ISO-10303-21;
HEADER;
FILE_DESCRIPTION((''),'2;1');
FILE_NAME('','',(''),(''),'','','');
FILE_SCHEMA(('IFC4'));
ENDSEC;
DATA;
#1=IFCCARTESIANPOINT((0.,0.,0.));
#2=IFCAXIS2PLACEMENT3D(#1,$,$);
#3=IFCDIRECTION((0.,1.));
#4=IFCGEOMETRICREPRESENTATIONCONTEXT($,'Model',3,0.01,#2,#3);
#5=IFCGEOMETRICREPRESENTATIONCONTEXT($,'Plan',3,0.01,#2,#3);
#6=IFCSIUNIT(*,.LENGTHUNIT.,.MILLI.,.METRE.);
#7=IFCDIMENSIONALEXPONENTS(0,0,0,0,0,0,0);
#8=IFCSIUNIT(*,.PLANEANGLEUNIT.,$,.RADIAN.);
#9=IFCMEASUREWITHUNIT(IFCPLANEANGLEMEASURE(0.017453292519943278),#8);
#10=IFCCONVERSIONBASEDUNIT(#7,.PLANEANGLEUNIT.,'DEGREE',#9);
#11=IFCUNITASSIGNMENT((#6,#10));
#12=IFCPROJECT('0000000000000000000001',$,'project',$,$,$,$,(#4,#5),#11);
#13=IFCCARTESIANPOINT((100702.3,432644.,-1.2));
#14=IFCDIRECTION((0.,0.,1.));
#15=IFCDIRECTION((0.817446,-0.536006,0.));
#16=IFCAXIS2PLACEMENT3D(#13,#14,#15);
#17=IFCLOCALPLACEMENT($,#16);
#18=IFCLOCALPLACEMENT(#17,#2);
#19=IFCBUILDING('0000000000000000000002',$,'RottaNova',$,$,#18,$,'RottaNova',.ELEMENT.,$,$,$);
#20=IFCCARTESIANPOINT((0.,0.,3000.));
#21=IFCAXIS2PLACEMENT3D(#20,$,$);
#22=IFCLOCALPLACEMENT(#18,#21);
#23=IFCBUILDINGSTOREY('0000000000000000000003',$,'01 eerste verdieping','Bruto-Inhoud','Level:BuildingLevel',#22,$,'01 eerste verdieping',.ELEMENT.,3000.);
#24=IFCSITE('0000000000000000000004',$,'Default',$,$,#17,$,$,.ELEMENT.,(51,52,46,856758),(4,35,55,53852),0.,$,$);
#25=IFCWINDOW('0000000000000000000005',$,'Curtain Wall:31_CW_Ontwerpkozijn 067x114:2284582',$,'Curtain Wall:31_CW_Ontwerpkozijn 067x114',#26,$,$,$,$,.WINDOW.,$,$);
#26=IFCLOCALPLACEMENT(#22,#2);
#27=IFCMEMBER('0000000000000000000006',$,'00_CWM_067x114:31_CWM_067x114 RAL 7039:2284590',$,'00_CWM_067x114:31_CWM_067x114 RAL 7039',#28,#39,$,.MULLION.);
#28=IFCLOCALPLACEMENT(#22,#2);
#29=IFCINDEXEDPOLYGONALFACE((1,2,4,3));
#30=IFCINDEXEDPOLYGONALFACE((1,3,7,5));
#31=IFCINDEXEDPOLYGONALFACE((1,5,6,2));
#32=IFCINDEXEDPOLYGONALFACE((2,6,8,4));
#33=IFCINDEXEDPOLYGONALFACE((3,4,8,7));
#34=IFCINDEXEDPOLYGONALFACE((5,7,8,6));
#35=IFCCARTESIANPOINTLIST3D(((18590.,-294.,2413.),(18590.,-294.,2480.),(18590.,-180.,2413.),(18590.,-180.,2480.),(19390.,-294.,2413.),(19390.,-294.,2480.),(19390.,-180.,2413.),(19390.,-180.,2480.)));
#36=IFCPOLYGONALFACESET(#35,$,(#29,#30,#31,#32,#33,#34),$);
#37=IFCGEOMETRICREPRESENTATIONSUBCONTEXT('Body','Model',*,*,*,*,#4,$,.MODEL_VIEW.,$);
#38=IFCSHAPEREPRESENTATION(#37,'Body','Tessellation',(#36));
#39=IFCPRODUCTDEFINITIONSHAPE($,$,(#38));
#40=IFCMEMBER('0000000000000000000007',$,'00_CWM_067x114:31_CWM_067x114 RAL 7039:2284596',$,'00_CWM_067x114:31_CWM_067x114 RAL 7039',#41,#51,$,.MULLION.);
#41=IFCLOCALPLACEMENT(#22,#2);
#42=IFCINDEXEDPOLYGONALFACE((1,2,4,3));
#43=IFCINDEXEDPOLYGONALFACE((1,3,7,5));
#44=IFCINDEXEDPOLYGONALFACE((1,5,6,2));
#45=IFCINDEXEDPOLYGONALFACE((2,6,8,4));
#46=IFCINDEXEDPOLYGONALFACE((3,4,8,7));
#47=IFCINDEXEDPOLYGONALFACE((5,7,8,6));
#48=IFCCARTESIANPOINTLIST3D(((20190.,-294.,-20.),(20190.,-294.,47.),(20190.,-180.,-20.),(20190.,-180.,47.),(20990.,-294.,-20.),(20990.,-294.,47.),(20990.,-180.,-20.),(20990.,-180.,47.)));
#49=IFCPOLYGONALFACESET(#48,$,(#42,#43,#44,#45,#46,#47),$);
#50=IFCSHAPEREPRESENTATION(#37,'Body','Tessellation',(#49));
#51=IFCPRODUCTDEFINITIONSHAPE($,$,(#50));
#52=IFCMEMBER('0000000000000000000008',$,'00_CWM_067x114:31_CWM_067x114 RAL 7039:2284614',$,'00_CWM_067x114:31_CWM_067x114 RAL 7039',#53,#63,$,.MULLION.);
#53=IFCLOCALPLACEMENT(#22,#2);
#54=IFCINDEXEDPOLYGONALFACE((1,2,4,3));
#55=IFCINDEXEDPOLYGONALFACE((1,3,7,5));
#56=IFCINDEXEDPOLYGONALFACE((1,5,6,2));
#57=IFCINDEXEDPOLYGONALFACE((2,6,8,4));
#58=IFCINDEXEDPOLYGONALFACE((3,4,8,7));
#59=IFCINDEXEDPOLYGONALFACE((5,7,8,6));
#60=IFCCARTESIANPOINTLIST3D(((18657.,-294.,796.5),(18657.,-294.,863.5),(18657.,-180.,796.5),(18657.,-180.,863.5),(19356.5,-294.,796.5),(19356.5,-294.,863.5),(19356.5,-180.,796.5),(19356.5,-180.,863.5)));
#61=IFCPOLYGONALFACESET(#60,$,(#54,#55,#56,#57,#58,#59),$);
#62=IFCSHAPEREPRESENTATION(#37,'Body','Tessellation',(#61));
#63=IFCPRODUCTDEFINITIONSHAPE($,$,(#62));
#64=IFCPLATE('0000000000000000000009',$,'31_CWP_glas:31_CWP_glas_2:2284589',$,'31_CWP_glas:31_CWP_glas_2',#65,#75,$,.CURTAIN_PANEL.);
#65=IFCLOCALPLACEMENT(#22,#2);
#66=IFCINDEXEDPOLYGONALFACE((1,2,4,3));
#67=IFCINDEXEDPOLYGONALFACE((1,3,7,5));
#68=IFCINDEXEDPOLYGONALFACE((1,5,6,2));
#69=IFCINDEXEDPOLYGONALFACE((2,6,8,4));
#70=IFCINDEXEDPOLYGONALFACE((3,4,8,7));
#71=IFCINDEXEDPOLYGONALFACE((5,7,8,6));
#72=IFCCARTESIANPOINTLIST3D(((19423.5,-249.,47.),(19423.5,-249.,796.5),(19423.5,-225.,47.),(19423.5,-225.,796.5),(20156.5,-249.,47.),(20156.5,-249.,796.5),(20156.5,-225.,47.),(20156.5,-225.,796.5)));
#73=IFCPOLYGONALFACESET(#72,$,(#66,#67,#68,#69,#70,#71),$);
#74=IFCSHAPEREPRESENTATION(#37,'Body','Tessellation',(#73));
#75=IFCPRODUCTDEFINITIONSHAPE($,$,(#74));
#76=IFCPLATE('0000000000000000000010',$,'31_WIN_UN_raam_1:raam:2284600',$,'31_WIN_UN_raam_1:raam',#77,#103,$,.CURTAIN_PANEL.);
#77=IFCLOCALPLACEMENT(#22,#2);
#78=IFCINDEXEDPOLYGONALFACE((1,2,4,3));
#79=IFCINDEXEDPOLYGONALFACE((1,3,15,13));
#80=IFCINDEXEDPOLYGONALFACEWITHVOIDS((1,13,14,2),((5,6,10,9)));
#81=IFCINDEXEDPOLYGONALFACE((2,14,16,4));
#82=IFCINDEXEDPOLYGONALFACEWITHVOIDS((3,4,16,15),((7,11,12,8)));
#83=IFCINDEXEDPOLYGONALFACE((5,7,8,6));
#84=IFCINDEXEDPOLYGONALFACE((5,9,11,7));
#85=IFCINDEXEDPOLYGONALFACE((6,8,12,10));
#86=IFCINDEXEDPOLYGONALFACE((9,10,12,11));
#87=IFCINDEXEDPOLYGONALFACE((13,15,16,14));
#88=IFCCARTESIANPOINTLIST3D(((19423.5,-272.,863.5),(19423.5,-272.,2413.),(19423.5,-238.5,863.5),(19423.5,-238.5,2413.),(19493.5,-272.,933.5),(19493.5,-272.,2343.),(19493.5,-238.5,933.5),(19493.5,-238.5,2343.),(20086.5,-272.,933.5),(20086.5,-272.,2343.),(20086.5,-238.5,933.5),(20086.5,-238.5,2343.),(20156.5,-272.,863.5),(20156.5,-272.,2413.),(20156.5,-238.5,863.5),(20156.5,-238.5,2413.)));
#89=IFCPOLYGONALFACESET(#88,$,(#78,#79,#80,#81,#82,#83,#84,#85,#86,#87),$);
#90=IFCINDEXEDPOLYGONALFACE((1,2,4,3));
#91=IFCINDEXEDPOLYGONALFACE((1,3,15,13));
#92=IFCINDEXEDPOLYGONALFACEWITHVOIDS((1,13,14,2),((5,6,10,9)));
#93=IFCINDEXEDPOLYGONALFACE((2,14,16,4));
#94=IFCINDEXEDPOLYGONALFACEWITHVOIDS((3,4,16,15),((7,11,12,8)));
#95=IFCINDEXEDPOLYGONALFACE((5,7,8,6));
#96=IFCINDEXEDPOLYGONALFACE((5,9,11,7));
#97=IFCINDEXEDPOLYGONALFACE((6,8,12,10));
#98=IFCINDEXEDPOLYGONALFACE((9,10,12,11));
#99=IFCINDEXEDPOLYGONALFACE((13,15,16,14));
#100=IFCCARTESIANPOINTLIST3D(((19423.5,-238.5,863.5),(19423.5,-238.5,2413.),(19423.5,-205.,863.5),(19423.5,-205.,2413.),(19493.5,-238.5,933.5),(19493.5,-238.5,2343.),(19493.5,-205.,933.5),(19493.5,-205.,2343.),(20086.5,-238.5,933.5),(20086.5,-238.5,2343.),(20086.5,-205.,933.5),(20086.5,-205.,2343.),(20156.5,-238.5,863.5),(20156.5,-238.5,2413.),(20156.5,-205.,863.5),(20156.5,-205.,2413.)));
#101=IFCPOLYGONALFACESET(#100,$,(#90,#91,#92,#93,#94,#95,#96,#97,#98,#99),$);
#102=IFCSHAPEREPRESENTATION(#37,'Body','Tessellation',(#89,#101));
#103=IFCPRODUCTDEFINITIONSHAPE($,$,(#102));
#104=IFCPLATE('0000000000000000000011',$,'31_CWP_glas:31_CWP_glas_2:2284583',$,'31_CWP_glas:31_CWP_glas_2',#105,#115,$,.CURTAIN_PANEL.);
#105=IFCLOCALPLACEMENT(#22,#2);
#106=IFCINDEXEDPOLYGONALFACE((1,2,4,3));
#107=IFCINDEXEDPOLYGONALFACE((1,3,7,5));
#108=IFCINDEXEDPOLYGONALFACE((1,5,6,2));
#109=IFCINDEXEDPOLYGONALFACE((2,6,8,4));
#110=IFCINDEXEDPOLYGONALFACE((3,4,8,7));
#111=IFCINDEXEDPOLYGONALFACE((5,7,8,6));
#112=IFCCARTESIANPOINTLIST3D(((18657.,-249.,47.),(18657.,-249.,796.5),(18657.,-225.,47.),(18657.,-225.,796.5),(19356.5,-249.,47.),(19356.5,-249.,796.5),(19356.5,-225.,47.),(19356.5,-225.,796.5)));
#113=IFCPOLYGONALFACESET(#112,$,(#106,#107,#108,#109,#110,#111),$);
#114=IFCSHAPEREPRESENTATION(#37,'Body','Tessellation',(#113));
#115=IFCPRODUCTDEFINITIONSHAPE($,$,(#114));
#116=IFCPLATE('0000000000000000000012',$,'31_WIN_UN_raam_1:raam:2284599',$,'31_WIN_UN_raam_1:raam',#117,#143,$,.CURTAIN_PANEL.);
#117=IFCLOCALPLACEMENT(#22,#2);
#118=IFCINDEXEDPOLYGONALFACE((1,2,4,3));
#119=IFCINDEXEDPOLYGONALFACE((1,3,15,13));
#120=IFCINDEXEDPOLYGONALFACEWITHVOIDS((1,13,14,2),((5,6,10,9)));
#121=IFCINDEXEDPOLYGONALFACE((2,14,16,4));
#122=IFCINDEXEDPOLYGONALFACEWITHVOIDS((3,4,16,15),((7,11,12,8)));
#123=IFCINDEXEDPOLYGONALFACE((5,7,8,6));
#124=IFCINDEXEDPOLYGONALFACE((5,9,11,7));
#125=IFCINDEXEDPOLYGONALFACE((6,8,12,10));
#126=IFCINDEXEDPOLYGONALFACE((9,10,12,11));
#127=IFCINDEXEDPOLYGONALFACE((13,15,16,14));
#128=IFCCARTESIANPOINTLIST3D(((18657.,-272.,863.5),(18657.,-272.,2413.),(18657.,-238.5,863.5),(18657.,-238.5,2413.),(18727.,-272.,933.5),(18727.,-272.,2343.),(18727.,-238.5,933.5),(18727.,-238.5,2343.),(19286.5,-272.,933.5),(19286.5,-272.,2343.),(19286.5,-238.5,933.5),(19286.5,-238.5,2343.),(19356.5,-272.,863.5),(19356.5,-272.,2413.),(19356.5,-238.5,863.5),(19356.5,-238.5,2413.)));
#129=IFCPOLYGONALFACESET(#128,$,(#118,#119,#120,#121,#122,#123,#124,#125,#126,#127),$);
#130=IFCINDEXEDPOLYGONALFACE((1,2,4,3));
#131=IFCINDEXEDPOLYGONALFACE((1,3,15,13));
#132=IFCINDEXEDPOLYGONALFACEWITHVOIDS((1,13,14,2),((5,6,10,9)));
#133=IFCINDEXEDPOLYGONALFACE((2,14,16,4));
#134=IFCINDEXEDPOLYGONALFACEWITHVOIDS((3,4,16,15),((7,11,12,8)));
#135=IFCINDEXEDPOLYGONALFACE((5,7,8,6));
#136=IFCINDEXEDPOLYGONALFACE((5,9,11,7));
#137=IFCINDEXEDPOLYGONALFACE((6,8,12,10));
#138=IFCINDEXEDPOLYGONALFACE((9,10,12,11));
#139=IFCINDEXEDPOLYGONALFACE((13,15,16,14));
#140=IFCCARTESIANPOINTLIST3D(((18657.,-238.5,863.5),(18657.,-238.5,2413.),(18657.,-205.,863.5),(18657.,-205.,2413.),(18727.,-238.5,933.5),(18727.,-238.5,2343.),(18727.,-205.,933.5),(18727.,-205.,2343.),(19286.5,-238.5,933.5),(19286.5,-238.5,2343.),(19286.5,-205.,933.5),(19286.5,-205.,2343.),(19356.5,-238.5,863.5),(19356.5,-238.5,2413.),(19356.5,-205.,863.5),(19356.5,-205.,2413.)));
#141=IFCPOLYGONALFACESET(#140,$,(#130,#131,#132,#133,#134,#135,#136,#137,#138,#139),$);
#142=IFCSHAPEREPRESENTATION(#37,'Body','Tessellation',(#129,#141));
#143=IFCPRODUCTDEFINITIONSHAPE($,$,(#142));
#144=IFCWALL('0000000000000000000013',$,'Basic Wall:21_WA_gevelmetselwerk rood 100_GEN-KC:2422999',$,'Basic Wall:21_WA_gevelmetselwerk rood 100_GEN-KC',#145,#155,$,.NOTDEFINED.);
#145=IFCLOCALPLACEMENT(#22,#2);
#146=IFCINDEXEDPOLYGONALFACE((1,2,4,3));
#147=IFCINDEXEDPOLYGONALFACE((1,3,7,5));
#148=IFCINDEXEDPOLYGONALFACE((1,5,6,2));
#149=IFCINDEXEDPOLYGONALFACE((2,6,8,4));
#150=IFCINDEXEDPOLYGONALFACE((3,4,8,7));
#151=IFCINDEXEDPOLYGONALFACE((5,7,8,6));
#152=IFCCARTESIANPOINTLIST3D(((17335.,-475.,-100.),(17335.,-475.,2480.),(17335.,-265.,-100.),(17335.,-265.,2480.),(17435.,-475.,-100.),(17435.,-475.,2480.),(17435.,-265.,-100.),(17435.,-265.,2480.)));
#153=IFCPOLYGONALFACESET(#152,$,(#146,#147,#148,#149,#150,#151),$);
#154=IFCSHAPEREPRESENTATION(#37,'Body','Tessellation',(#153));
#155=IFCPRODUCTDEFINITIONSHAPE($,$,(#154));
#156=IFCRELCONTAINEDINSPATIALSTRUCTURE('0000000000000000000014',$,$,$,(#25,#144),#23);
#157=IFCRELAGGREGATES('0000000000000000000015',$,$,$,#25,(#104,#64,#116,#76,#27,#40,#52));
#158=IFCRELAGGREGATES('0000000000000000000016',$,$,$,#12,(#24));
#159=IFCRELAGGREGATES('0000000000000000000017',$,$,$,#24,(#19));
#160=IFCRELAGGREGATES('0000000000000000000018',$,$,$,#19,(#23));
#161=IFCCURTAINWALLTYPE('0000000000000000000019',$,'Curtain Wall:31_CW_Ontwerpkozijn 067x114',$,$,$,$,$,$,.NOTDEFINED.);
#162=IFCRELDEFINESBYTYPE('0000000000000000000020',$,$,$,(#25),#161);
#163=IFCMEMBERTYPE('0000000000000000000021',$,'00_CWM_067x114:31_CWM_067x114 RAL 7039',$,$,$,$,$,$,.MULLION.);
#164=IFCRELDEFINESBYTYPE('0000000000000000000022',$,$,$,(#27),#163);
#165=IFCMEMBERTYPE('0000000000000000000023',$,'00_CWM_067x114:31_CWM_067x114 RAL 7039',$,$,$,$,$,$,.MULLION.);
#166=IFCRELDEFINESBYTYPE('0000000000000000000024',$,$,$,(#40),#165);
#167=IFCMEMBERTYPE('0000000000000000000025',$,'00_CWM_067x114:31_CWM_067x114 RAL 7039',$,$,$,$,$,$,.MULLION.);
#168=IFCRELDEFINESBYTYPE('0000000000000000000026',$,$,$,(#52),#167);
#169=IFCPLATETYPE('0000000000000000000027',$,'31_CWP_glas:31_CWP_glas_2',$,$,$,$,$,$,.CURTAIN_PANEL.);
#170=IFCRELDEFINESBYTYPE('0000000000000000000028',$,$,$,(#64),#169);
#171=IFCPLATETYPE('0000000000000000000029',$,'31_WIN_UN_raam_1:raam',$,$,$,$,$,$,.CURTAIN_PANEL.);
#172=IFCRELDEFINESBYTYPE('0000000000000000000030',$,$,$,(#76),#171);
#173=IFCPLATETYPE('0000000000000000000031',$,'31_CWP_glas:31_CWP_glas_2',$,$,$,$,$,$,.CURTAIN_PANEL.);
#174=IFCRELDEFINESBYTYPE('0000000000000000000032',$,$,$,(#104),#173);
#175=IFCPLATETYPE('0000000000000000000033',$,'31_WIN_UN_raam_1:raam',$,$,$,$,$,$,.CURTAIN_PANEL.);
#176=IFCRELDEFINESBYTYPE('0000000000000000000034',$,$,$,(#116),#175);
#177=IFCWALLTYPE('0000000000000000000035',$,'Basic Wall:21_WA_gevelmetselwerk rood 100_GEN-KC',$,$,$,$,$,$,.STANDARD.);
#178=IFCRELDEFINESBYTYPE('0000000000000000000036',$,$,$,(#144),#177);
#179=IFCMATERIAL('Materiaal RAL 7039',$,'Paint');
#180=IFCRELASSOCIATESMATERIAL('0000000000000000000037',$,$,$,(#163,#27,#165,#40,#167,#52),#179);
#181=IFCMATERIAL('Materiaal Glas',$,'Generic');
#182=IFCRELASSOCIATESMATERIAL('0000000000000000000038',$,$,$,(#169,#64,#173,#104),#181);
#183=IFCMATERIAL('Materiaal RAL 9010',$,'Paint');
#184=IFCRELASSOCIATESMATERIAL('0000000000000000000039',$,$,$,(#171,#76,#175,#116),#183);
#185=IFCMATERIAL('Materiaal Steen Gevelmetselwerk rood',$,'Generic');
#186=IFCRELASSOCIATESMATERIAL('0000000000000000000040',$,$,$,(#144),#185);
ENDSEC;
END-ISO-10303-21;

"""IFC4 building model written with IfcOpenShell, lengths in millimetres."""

from ifc_helpers import new_model, entity, si_unit, converted_unit, direction, frame, origin, place, context, subcontext, project, spatial, indexed_curve, outline, extrude, source, transform, mapped, material, type_object, type_shapes, element, aggregate, save


model = new_model("IFC4")

# Units and contexts
model_context = context("Model", 3, precision=0.01, world=origin(), true_north=direction((0.0, 1.0)))
plan_context = context("Plan", 3, precision=0.01, world=origin(), true_north=direction((0.0, 1.0)))
body_context = subcontext(model_context, "Body", "Model", "MODEL_VIEW")
ifc_project = project(units=[si_unit("LENGTHUNIT", "METRE", prefix="MILLI"), converted_unit("PLANEANGLEUNIT", "DEGREE", entity("IfcPlaneAngleMeasure", 0.017453292519943278), si_unit("PLANEANGLEUNIT", "RADIAN"), dimensions=[0, 0, 0, 0, 0, 0, 0])], contexts=[model_context, plan_context])

# Site, building, storey
site_placement = place(None, frame((100702.3, 432644.0, -1.2), z_axis=(0.0, 0.0, 1.0), x_axis=(0.817446, -0.536006, 0.0)))
site = spatial("IfcSite", under=ifc_project, at=site_placement, Name="Default", CompositionType="ELEMENT", RefLatitude=(51, 52, 46, 856758), RefLongitude=(4, 35, 55, 53852), RefElevation=0.0)
building_placement = place(site_placement, origin())
building = spatial("IfcBuilding", under=site, at=building_placement, Name="RottaNova", LongName="RottaNova", CompositionType="ELEMENT")
storey_placement = place(building_placement, frame((0.0, 0.0, 3000.0)))
storey = spatial("IfcBuildingStorey", under=building, at=storey_placement, Name="01 eerste verdieping", Description="Bruto-Inhoud", ObjectType="Level:BuildingLevel", LongName="01 eerste verdieping", CompositionType="ELEMENT", Elevation=3000.0)

# Window, members, plates
curtain_wall_type = type_object("IfcCurtainWallType", Name="Curtain Wall:31_CW_Ontwerpkozijn 067x114", PredefinedType="NOTDEFINED")
window_1_placement = place(storey_placement, frame((0.0, 0.0, -3000.0)))
window_1 = element("IfcWindow", 1, at=window_1_placement, inside=storey, type_object=curtain_wall_type, Name="Curtain Wall:31_CW_Ontwerpkozijn 067x114:2284582", ObjectType="Curtain Wall:31_CW_Ontwerpkozijn 067x114", PredefinedType="WINDOW")
ifc_material_1 = material(Name="Materiaal RAL 7039", Category="Paint")
member_type_1 = type_object("IfcMemberType", Name="00_CWM_067x114:31_CWM_067x114 RAL 7039", PredefinedType="MULLION", material=ifc_material_1)
shared_shape_1 = source(origin(), body_context, "Body", "SweptSolid", [
    extrude(outline(indexed_curve([(-33.5, -57.0), (33.5, -57.0), (33.5, 57.0), (-33.5, 57.0), (-33.5, -57.0)], self_intersect=False)), frame((-33.5, 57.0, -800.0), z_axis=(0.0, 0.0, 1.0), x_axis=(-1.0, 0.0, 0.0)), (0.0, 0.0, 1.0), 800.0),
])
type_shapes(member_type_1, [shared_shape_1])
member_1_placement = place(window_1_placement, frame((19390.0, -180.0, 5480.0), z_axis=(1.0, 0.0, 0.0), x_axis=(0.0, 0.0, 1.0)))
member_1 = element("IfcMember", 2, at=member_1_placement, type_object=member_type_1, material=ifc_material_1, Name="00_CWM_067x114:31_CWM_067x114 RAL 7039:2284590", ObjectType="00_CWM_067x114:31_CWM_067x114 RAL 7039", PredefinedType="MULLION", context=body_context, shape_type="MappedRepresentation", body=[
    mapped(shared_shape_1, transform((0.0, 0.0, 0.0), scale=1.0)),
])
member_type_2 = type_object("IfcMemberType", Name="00_CWM_067x114:31_CWM_067x114 RAL 7039", PredefinedType="MULLION", material=ifc_material_1)
shared_shape_2 = source(origin(), body_context, "Body", "SweptSolid", [
    extrude(outline(indexed_curve([(-33.5, -57.0), (33.5, -57.0), (33.5, 57.0), (-33.5, 57.0), (-33.5, -57.0)], self_intersect=False)), frame((-33.5, 57.0, -800.0), z_axis=(0.0, 0.0, 1.0), x_axis=(-1.0, 0.0, 0.0)), (0.0, 0.0, 1.0), 800.0),
])
type_shapes(member_type_2, [shared_shape_2])
member_2_placement = place(window_1_placement, frame((20190.0, -180.0, 2980.0), z_axis=(-1.0, 0.0, 0.0), x_axis=(0.0, 0.0, -1.0)))
member_2 = element("IfcMember", 3, at=member_2_placement, type_object=member_type_2, material=ifc_material_1, Name="00_CWM_067x114:31_CWM_067x114 RAL 7039:2284596", ObjectType="00_CWM_067x114:31_CWM_067x114 RAL 7039", PredefinedType="MULLION", context=body_context, shape_type="MappedRepresentation", body=[
    mapped(shared_shape_2, transform((0.0, 0.0, 0.0), scale=1.0)),
])
member_type_3 = type_object("IfcMemberType", Name="00_CWM_067x114:31_CWM_067x114 RAL 7039", PredefinedType="MULLION", material=ifc_material_1)
shared_shape_3 = source(origin(), body_context, "Body", "SweptSolid", [
    extrude(outline(indexed_curve([(-33.5, -57.0), (33.5, -57.0), (33.5, 57.0), (-33.5, 57.0), (-33.5, -57.0)], self_intersect=False)), frame((0.0, 57.0, -699.5), z_axis=(0.0, 0.0, 1.0), x_axis=(-1.0, 0.0, 0.0)), (0.0, 0.0, 1.0), 699.5),
])
type_shapes(member_type_3, [shared_shape_3])
member_3_placement = place(window_1_placement, frame((19356.5, -180.0, 3830.0), z_axis=(1.0, 0.0, 0.0), x_axis=(0.0, 0.0, 1.0)))
member_3 = element("IfcMember", 4, at=member_3_placement, type_object=member_type_3, material=ifc_material_1, Name="00_CWM_067x114:31_CWM_067x114 RAL 7039:2284614", ObjectType="00_CWM_067x114:31_CWM_067x114 RAL 7039", PredefinedType="MULLION", context=body_context, shape_type="MappedRepresentation", body=[
    mapped(shared_shape_3, transform((0.0, 0.0, 0.0), scale=1.0)),
])
ifc_material_2 = material(Name="Materiaal Glas", Category="Generic")
plate_type_1 = type_object("IfcPlateType", Name="31_CWP_glas:31_CWP_glas_2", PredefinedType="CURTAIN_PANEL", material=ifc_material_2)
shared_shape_4 = source(origin(), body_context, "Body", "SweptSolid", [
    extrude(outline(indexed_curve([(-12.0, -366.5), (12.0, -366.5), (12.0, 366.5), (-12.0, 366.5), (-12.0, -366.5)], self_intersect=False)), frame((0.0, -57.0, 0.0), z_axis=(0.0, 0.0, 1.0), x_axis=(0.0, 1.0, 0.0)), (0.0, 0.0, 1.0), 749.5),
])
type_shapes(plate_type_1, [shared_shape_4])
plate_1_placement = place(window_1_placement, frame((19790.0, -180.0, 3047.0)))
plate_1 = element("IfcPlate", 5, at=plate_1_placement, type_object=plate_type_1, material=ifc_material_2, Name="31_CWP_glas:31_CWP_glas_2:2284589", ObjectType="31_CWP_glas:31_CWP_glas_2", PredefinedType="CURTAIN_PANEL", context=body_context, shape_type="MappedRepresentation", body=[
    mapped(shared_shape_4, transform((0.0, 0.0, 0.0), scale=1.0)),
])
ifc_material_3 = material(Name="Materiaal RAL 9010", Category="Paint")
plate_type_2 = type_object("IfcPlateType", Name="31_WIN_UN_raam_1:raam", PredefinedType="CURTAIN_PANEL", material=ifc_material_3)
shared_shape_5 = source(origin(), body_context, "Body", "SweptSolid", [
    extrude(outline(indexed_curve([(-366.5, -774.8), (366.5, -774.8), (366.5, 774.8), (-366.5, 774.8), (-366.5, -774.8)], self_intersect=False), holes=[indexed_curve([(-296.5, 704.8), (296.5, 704.8), (296.5, -704.8), (-296.5, -704.8), (-296.5, 704.8)], self_intersect=False)]), frame((0.0, -92.0, 774.8), z_axis=(0.0, 1.0, 0.0), x_axis=(1.0, 0.0, 0.0)), (0.0, 0.0, 1.0), 33.5),
    extrude(outline(indexed_curve([(-366.5, -774.8), (366.5, -774.8), (366.5, 774.8), (-366.5, 774.8), (-366.5, -774.8)], self_intersect=False), holes=[indexed_curve([(-296.5, 704.7), (296.5, 704.7), (296.5, -704.8), (-296.5, -704.8), (-296.5, 704.7)], self_intersect=False)]), frame((0.0, -58.5, 774.8), z_axis=(0.0, 1.0, 0.0), x_axis=(1.0, 0.0, 0.0)), (0.0, 0.0, 1.0), 33.5),
])
type_shapes(plate_type_2, [shared_shape_5])
plate_2_placement = place(window_1_placement, frame((19790.0, -180.0, 3863.5)))
plate_2 = element("IfcPlate", 6, at=plate_2_placement, type_object=plate_type_2, material=ifc_material_3, Name="31_WIN_UN_raam_1:raam:2284600", ObjectType="31_WIN_UN_raam_1:raam", PredefinedType="CURTAIN_PANEL", context=body_context, shape_type="MappedRepresentation", body=[
    mapped(shared_shape_5, transform((0.0, 0.0, 0.0), scale=1.0)),
])
plate_type_3 = type_object("IfcPlateType", Name="31_CWP_glas:31_CWP_glas_2", PredefinedType="CURTAIN_PANEL", material=ifc_material_2)
shared_shape_6 = source(origin(), body_context, "Body", "SweptSolid", [
    extrude(outline(indexed_curve([(-12.0, -349.7), (12.0, -349.7), (12.0, 349.7), (-12.0, 349.7), (-12.0, -349.7)], self_intersect=False)), frame((0.0, -57.0, 0.0), z_axis=(0.0, 0.0, 1.0), x_axis=(0.0, 1.0, 0.0)), (0.0, 0.0, 1.0), 749.5),
])
type_shapes(plate_type_3, [shared_shape_6])
plate_3_placement = place(window_1_placement, frame((19006.8, -180.0, 3047.0)))
plate_3 = element("IfcPlate", 7, at=plate_3_placement, type_object=plate_type_3, material=ifc_material_2, Name="31_CWP_glas:31_CWP_glas_2:2284583", ObjectType="31_CWP_glas:31_CWP_glas_2", PredefinedType="CURTAIN_PANEL", context=body_context, shape_type="MappedRepresentation", body=[
    mapped(shared_shape_6, transform((0.0, 0.0, 0.0), scale=1.0)),
])
plate_type_4 = type_object("IfcPlateType", Name="31_WIN_UN_raam_1:raam", PredefinedType="CURTAIN_PANEL", material=ifc_material_3)
shared_shape_7 = source(origin(), body_context, "Body", "SweptSolid", [
    extrude(outline(indexed_curve([(-349.7, -774.8), (349.7, -774.8), (349.7, 774.8), (-349.7, 774.8), (-349.7, -774.8)], self_intersect=False), holes=[indexed_curve([(-279.7, 704.8), (279.7, 704.8), (279.7, -704.8), (-279.7, -704.8), (-279.7, 704.8)], self_intersect=False)]), frame((0.0, -92.0, 774.8), z_axis=(0.0, 1.0, 0.0), x_axis=(1.0, 0.0, 0.0)), (0.0, 0.0, 1.0), 33.5),
    extrude(outline(indexed_curve([(-349.7, -774.8), (349.7, -774.8), (349.7, 774.8), (-349.7, 774.8), (-349.7, -774.8)], self_intersect=False), holes=[indexed_curve([(-279.7, 704.7), (279.7, 704.7), (279.7, -704.8), (-279.7, -704.8), (-279.7, 704.7)], self_intersect=False)]), frame((0.0, -58.5, 774.8), z_axis=(0.0, 1.0, 0.0), x_axis=(1.0, 0.0, 0.0)), (0.0, 0.0, 1.0), 33.5),
])
type_shapes(plate_type_4, [shared_shape_7])
plate_4_placement = place(window_1_placement, frame((19006.8, -180.0, 3863.5)))
plate_4 = element("IfcPlate", 8, at=plate_4_placement, type_object=plate_type_4, material=ifc_material_3, Name="31_WIN_UN_raam_1:raam:2284599", ObjectType="31_WIN_UN_raam_1:raam", PredefinedType="CURTAIN_PANEL", context=body_context, shape_type="MappedRepresentation", body=[
    mapped(shared_shape_7, transform((0.0, 0.0, 0.0), scale=1.0)),
])
aggregate(window_1, [plate_3, plate_1, plate_4, plate_2, member_1, member_2, member_3])

# Wall
ifc_material_4 = material(Name="Materiaal Steen Gevelmetselwerk rood", Category="Generic")
wall_type = type_object("IfcWallType", Name="Basic Wall:21_WA_gevelmetselwerk rood 100_GEN-KC", PredefinedType="STANDARD")
wall_1_placement = place(storey_placement, frame((17385.0, -265.0, -100.0), z_axis=(0.0, 0.0, 1.0), x_axis=(0.0, -1.0, 0.0)))
element("IfcWall", 9, at=wall_1_placement, inside=storey, type_object=wall_type, material=ifc_material_4, Name="Basic Wall:21_WA_gevelmetselwerk rood 100_GEN-KC:2422999", ObjectType="Basic Wall:21_WA_gevelmetselwerk rood 100_GEN-KC", PredefinedType="NOTDEFINED", context=body_context, shape_type="SweptSolid", body=[
    extrude(outline(indexed_curve([(210.0, 50.0), (0.0, 50.0), (0.0, -50.0), (210.0, -50.0), (210.0, 50.0)], self_intersect=False)), origin(), (0.0, 0.0, 1.0), 2580.0),
])

save(model, "model.ifc")
